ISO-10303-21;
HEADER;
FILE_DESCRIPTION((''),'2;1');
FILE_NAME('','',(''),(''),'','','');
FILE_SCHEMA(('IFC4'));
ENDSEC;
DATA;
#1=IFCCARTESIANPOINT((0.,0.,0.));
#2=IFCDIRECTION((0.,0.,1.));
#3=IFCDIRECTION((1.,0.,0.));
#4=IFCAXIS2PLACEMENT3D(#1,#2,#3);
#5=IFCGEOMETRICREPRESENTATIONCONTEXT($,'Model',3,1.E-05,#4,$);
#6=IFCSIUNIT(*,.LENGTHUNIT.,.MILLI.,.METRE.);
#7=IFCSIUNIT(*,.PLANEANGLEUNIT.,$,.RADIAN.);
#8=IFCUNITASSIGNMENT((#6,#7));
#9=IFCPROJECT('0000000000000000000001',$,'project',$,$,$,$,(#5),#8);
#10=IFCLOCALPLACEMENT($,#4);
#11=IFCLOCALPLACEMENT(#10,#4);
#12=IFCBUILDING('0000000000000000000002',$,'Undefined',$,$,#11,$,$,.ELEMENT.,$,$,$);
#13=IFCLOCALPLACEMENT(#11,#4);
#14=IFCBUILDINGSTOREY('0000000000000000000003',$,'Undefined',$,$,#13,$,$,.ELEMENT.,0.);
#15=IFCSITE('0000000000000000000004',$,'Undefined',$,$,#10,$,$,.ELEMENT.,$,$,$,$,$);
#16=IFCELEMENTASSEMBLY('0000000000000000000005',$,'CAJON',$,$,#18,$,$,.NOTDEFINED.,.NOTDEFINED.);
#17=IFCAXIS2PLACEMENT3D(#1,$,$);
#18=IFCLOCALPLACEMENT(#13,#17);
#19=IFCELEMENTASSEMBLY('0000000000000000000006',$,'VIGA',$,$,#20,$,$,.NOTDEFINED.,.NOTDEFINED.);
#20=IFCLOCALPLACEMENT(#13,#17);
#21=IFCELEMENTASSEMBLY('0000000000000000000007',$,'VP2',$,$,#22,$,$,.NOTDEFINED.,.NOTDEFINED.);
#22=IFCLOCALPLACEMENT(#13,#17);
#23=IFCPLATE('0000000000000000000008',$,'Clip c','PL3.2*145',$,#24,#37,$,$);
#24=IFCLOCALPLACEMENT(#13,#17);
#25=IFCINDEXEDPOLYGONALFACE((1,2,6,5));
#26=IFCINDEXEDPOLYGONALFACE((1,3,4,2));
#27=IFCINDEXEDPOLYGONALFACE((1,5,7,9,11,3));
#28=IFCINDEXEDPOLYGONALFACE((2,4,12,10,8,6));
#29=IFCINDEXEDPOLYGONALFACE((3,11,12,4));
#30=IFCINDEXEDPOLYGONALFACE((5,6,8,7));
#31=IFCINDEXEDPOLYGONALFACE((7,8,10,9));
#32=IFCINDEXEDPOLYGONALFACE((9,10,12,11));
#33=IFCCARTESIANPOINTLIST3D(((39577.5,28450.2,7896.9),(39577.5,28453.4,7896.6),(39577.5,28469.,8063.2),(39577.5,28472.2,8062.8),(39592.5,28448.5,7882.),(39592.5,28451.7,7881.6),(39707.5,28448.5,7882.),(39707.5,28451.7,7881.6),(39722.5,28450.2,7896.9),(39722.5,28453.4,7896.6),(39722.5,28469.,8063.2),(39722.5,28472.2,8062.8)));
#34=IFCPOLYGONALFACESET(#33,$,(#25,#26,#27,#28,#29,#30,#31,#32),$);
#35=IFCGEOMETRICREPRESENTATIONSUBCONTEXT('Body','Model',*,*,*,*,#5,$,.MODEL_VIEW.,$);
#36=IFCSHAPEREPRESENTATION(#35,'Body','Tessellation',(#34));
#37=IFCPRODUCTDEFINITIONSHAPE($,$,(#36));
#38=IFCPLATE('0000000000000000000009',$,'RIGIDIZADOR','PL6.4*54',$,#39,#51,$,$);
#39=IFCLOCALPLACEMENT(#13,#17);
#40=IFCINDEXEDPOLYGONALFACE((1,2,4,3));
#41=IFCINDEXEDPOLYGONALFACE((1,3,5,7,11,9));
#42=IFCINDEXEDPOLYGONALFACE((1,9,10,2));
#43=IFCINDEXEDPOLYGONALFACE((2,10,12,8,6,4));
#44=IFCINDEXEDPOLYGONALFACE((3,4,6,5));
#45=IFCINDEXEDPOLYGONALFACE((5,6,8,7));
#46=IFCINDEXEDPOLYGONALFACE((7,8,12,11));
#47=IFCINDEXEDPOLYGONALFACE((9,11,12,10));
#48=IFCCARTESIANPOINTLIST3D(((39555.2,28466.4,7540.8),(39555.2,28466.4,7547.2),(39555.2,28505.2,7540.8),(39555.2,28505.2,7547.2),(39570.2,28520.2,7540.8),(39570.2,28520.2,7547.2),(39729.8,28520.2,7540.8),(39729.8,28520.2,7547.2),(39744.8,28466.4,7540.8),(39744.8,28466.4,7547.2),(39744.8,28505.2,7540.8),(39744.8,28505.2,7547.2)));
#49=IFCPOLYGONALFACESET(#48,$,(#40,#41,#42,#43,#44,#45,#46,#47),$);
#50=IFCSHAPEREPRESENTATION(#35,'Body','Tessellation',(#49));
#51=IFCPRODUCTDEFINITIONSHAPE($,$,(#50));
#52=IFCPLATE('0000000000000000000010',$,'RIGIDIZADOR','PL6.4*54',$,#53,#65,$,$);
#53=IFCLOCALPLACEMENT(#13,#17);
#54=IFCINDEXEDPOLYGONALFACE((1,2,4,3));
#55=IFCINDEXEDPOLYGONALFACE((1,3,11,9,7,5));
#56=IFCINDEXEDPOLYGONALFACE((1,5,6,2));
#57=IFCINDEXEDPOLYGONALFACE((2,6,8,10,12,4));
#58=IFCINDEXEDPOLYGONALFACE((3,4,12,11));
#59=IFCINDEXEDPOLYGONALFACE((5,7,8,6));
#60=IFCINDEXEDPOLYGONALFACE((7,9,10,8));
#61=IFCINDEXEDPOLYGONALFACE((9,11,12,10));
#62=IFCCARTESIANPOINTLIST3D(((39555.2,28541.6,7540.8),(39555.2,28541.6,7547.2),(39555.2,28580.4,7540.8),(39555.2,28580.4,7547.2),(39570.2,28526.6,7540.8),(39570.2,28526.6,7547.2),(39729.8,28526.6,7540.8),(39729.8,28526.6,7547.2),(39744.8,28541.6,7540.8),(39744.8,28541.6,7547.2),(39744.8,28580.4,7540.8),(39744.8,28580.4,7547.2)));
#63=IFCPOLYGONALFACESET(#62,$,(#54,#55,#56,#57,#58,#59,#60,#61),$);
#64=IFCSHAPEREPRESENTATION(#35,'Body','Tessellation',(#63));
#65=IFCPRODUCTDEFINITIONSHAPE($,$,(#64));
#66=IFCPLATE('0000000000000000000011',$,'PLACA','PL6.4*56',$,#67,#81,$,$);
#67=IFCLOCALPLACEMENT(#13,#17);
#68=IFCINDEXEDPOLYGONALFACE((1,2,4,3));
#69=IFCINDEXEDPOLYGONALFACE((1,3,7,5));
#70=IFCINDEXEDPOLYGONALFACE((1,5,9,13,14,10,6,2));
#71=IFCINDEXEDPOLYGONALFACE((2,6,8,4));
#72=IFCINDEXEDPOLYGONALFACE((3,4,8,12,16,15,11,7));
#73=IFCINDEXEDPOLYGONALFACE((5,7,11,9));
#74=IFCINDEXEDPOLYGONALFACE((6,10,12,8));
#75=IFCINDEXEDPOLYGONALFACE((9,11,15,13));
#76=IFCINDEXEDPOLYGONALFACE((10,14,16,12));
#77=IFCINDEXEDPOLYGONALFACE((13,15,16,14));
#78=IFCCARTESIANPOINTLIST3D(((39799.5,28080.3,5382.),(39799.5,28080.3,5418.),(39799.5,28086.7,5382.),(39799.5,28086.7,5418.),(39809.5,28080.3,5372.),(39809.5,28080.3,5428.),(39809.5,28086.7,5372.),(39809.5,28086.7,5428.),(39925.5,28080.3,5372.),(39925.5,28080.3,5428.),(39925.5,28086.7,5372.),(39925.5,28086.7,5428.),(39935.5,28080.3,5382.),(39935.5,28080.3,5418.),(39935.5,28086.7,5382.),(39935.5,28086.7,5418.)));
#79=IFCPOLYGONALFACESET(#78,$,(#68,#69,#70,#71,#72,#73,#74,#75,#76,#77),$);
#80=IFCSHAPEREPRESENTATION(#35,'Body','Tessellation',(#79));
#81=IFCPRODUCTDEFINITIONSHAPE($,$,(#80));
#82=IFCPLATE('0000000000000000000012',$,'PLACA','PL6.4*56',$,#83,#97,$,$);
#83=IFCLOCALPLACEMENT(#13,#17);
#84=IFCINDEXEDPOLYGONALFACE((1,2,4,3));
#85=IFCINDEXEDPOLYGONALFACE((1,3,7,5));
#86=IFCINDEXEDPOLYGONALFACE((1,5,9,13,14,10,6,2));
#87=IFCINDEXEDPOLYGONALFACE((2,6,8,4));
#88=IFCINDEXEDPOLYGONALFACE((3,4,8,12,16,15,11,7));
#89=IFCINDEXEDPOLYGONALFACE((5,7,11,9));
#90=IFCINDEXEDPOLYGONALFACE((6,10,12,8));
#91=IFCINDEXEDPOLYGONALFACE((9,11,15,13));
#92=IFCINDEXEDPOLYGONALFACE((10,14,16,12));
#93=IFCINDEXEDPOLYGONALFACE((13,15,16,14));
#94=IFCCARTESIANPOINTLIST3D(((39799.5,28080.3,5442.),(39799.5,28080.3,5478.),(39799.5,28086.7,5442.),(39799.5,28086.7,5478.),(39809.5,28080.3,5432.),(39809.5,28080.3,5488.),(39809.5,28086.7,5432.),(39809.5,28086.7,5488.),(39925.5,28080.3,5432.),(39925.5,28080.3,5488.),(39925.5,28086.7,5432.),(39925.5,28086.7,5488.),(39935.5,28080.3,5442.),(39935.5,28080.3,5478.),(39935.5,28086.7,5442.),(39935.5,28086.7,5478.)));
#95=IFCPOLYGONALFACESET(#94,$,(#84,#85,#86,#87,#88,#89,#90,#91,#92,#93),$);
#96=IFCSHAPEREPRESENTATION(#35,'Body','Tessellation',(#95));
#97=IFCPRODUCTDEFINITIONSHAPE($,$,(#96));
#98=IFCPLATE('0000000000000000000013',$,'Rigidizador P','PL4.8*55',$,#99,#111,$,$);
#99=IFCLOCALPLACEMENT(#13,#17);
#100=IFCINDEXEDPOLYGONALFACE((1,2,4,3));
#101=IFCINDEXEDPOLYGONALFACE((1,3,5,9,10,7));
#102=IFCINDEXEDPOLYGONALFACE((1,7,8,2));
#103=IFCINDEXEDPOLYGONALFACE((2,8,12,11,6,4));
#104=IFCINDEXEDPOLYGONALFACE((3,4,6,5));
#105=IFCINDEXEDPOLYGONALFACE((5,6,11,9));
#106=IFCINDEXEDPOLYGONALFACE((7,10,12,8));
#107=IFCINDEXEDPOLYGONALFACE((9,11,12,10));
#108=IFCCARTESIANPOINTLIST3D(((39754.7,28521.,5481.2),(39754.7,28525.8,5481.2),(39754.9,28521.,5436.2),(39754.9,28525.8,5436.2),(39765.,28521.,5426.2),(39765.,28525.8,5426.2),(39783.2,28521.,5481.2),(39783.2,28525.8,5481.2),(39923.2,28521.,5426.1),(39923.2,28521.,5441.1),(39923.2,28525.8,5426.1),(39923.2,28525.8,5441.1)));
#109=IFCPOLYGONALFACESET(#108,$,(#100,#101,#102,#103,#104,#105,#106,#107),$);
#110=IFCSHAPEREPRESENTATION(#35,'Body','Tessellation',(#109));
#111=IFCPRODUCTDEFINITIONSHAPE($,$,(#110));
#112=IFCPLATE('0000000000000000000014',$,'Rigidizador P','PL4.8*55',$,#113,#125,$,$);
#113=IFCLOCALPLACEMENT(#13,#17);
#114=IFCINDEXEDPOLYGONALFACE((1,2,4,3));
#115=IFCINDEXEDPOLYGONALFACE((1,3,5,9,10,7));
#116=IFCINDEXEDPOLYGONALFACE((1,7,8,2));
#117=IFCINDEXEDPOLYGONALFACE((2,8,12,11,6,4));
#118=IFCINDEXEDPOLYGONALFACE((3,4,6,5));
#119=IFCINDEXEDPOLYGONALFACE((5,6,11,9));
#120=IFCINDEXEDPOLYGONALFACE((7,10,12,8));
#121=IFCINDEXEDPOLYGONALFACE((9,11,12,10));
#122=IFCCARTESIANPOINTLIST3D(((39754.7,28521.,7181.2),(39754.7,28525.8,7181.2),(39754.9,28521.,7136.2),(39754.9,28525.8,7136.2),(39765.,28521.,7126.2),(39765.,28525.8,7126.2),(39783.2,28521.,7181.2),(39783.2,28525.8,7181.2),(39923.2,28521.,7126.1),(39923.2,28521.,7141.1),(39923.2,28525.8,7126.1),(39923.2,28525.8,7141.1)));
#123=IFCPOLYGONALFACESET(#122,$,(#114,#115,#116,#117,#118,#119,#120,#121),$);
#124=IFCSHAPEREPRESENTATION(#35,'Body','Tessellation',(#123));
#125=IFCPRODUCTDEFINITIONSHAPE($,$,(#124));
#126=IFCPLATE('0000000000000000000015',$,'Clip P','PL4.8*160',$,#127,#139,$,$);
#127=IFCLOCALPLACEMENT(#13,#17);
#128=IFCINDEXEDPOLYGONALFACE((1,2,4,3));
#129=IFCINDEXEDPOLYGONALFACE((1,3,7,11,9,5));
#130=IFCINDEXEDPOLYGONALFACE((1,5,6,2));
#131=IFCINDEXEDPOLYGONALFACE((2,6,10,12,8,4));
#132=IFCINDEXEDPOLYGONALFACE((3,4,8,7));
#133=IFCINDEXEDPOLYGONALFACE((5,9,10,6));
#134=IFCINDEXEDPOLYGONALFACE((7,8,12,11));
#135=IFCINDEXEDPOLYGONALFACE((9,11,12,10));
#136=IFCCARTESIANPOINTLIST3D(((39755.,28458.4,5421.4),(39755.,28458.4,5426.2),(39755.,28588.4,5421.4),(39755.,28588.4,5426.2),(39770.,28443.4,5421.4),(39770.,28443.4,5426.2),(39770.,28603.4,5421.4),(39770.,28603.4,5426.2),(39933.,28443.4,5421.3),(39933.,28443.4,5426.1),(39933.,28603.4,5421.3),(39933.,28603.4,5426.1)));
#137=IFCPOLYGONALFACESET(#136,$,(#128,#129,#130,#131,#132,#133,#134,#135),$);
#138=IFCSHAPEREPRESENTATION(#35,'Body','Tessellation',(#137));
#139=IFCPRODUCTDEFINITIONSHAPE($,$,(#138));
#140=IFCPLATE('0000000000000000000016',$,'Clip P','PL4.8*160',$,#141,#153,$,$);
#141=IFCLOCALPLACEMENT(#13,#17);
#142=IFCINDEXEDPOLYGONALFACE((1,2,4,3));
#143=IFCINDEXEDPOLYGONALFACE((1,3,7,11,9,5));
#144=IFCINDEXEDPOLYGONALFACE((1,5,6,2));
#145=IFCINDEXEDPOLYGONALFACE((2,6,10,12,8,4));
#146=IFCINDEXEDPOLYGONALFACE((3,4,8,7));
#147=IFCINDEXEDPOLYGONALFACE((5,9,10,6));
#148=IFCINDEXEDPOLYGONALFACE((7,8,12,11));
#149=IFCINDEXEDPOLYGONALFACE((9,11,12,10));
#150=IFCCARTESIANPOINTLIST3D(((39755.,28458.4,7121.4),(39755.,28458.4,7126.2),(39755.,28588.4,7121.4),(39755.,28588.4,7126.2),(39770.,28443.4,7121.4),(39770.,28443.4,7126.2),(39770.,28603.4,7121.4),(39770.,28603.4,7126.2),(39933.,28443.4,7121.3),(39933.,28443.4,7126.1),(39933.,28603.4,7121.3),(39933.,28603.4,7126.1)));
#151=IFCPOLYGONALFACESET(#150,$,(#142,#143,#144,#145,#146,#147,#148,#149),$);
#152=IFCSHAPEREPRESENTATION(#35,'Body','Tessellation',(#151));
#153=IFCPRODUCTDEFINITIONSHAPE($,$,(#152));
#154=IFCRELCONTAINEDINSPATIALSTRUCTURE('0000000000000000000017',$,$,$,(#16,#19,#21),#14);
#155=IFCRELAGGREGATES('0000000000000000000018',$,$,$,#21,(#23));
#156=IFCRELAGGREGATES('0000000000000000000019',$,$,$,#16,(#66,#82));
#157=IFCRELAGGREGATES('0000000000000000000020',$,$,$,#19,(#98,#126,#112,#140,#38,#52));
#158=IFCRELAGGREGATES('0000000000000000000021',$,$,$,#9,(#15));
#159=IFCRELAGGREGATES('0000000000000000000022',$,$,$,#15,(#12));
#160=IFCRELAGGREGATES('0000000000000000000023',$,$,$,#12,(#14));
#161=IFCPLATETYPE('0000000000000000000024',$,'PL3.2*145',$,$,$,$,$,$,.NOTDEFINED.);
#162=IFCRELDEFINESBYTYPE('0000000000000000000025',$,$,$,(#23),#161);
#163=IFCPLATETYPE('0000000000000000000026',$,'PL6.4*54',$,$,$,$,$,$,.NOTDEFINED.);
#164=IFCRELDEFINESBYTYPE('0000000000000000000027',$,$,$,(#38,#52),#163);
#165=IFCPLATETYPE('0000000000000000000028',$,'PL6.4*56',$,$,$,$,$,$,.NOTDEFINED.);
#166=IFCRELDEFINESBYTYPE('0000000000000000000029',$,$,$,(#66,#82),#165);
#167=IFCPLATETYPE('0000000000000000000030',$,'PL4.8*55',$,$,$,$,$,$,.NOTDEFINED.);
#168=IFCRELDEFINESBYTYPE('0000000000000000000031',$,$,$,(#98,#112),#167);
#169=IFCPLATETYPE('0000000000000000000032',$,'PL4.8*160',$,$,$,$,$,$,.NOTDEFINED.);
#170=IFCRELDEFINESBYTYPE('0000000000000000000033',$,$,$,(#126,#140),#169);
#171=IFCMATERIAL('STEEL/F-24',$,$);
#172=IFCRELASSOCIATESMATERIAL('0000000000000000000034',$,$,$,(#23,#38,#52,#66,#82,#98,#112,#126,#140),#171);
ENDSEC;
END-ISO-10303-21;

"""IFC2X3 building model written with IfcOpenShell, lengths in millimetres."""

from ifc_helpers import new_model, si_unit, frame, origin_with_axes, place, context, subcontext, project, spatial, polyline, outline, extrude, material, type_object, element, aggregate, save


model = new_model("IFC2X3")

# Units and contexts
model_context = context("Model", 3, precision=1e-05, world=origin_with_axes())
body_context = subcontext(model_context, "Body", "Model", "MODEL_VIEW")
ifc_project = project(units=[si_unit("LENGTHUNIT", "METRE", prefix="MILLI"), si_unit("PLANEANGLEUNIT", "RADIAN")], contexts=[model_context])

# Site, building, storey
site_placement = place(None, origin_with_axes())
site = spatial("IfcSite", under=ifc_project, at=site_placement, Name="Undefined", CompositionType="ELEMENT")
building_placement = place(site_placement, origin_with_axes())
building = spatial("IfcBuilding", under=site, at=building_placement, Name="Undefined", CompositionType="ELEMENT")
storey_placement = place(building_placement, origin_with_axes())
storey = spatial("IfcBuildingStorey", under=building, at=storey_placement, Name="Undefined", CompositionType="ELEMENT", Elevation=0.0)

# Shared definitions
ifc_material_1 = material(Name="STEEL/F-24")

# Element assembly
assembly_1_placement = place(storey_placement, origin_with_axes())
assembly_1 = element("IfcElementAssembly", 1, at=assembly_1_placement, inside=storey, Name="CAJON", AssemblyPlace="NOTDEFINED", PredefinedType="NOTDEFINED")

# Element assemblies, plate
assembly_2_placement = place(storey_placement, origin_with_axes())
assembly_2 = element("IfcElementAssembly", 2, at=assembly_2_placement, inside=storey, Name="VIGA", AssemblyPlace="NOTDEFINED", PredefinedType="NOTDEFINED")
assembly_3_placement = place(storey_placement, origin_with_axes())
assembly_3 = element("IfcElementAssembly", 3, at=assembly_3_placement, inside=storey, Name="VP2", AssemblyPlace="NOTDEFINED", PredefinedType="NOTDEFINED")
plate_type_1 = type_object("IfcPlateType", Name="PL3.2*145", PredefinedType="NOTDEFINED")
plate_1_placement = place(assembly_3_placement, frame((39722.5, 28450.1, 7881.8), z_axis=(0.0, -0.993645, 0.112559), x_axis=(0.0, 0.112559, 0.993645)))
plate_1 = element("IfcPlate", 4, at=plate_1_placement, type_object=plate_type_1, material=ifc_material_1, Name="Clip c", Description="PL3.2*145", context=body_context, shape_type="SweptSolid", body=[
    extrude(outline(polyline([(0.0, 15.0), (15.0, 0.0), (182.3, 0.0), (182.3, 145.0), (15.0, 145.0), (0.0, 130.0), (0.0, 15.0)])), frame((0.0, 0.0, -1.6), z_axis=(0.0, 0.0, 1.0), x_axis=(1.0, 0.0, 0.0)), (0.0, 0.0, 1.0), 3.2),
])
aggregate(assembly_3, [plate_1])

# Plates
plate_type_2 = type_object("IfcPlateType", Name="PL6.4*54", PredefinedType="NOTDEFINED")
plate_2_placement = place(assembly_2_placement, frame((39744.8, 28466.4, 7544.0), z_axis=(0.0, 0.0, 1.0), x_axis=(0.0, 1.0, 0.0)))
plate_2 = element("IfcPlate", 5, at=plate_2_placement, type_object=plate_type_2, material=ifc_material_1, Name="RIGIDIZADOR", Description="PL6.4*54", context=body_context, shape_type="SweptSolid", body=[
    extrude(outline(polyline([(0.0, 0.0), (38.8, 0.0), (53.8, 15.0), (53.8, 174.6), (38.8, 189.6), (0.0, 189.6), (0.0, 0.0)])), frame((0.0, 0.0, -3.2), z_axis=(0.0, 0.0, 1.0), x_axis=(1.0, 0.0, 0.0)), (0.0, 0.0, 1.0), 6.4),
])
plate_3_placement = place(assembly_2_placement, frame((39744.8, 28526.6, 7544.0), z_axis=(0.0, 0.0, 1.0), x_axis=(0.0, 1.0, 0.0)))
plate_3 = element("IfcPlate", 6, at=plate_3_placement, type_object=plate_type_2, material=ifc_material_1, Name="RIGIDIZADOR", Description="PL6.4*54", context=body_context, shape_type="SweptSolid", body=[
    extrude(outline(polyline([(0.0, 15.0), (15.0, 0.0), (53.8, 0.0), (53.8, 189.6), (15.0, 189.6), (0.0, 174.6), (0.0, 15.0)])), frame((0.0, 0.0, -3.2), z_axis=(0.0, 0.0, 1.0), x_axis=(1.0, 0.0, 0.0)), (0.0, 0.0, 1.0), 6.4),
])
plate_type_3 = type_object("IfcPlateType", Name="PL6.4*56", PredefinedType="NOTDEFINED")
plate_4_placement = place(assembly_1_placement, frame((39799.5, 28083.5, 5428.0), z_axis=(0.0, -1.0, -0.000002), x_axis=(0.0, 0.000002, -1.0)))
plate_4 = element("IfcPlate", 7, at=plate_4_placement, type_object=plate_type_3, material=ifc_material_1, Name="PLACA", Description="PL6.4*56", context=body_context, shape_type="SweptSolid", body=[
    extrude(outline(polyline([(0.0, 10.0), (10.0, 0.0), (46.0, 0.0), (56.0, 10.0), (56.0, 126.0), (46.0, 136.0), (10.0, 136.0), (0.0, 126.0), (0.0, 10.0)])), frame((0.0, 0.0, -3.2), z_axis=(0.0, 0.0, 1.0), x_axis=(1.0, 0.0, 0.0)), (0.0, 0.0, 1.0), 6.4),
])
plate_5_placement = place(assembly_1_placement, frame((39799.5, 28083.5, 5432.0), z_axis=(0.0, 1.0, 0.000002), x_axis=(0.0, -0.000002, 1.0)))
plate_5 = element("IfcPlate", 8, at=plate_5_placement, type_object=plate_type_3, material=ifc_material_1, Name="PLACA", Description="PL6.4*56", context=body_context, shape_type="SweptSolid", body=[
    extrude(outline(polyline([(0.0, 10.0), (10.0, 0.0), (46.0, 0.0), (56.0, 10.0), (56.0, 126.0), (46.0, 136.0), (10.0, 136.0), (0.0, 126.0), (0.0, 10.0)])), frame((0.0, 0.0, -3.2), z_axis=(0.0, 0.0, 1.0), x_axis=(1.0, 0.0, 0.0)), (0.0, 0.0, 1.0), 6.4),
])
plate_type_4 = type_object("IfcPlateType", Name="PL4.8*55", PredefinedType="NOTDEFINED")
plate_6_placement = place(assembly_2_placement, frame((39923.2, 28523.4, 5426.1), z_axis=(0.0, -1.0, 0.0), x_axis=(0.000256, 0.0, 1.0)))
plate_6 = element("IfcPlate", 9, at=plate_6_placement, type_object=plate_type_4, material=ifc_material_1, Name="Rigidizador P", Description="PL4.8*55", context=body_context, shape_type="SweptSolid", body=[
    extrude(outline(polyline([(0.0, 0.0), (15.0, 0.0), (55.1, 140.0), (55.1, 168.5), (10.1, 168.2), (0.1, 158.2), (0.0, 0.0)])), frame((0.0, 0.0, -2.4), z_axis=(0.0, 0.0, 1.0), x_axis=(1.0, 0.0, 0.0)), (0.0, 0.0, 1.0), 4.8),
])
plate_7_placement = place(assembly_2_placement, frame((39923.2, 28523.4, 7126.1), z_axis=(0.0, -1.0, 0.0), x_axis=(0.000256, 0.0, 1.0)))
plate_7 = element("IfcPlate", 10, at=plate_7_placement, type_object=plate_type_4, material=ifc_material_1, Name="Rigidizador P", Description="PL4.8*55", context=body_context, shape_type="SweptSolid", body=[
    extrude(outline(polyline([(0.0, 0.0), (15.0, 0.0), (55.1, 140.0), (55.1, 168.5), (10.1, 168.2), (0.1, 158.2), (0.0, 0.0)])), frame((0.0, 0.0, -2.4), z_axis=(0.0, 0.0, 1.0), x_axis=(1.0, 0.0, 0.0)), (0.0, 0.0, 1.0), 4.8),
])
plate_type_5 = type_object("IfcPlateType", Name="PL4.8*160", PredefinedType="NOTDEFINED")
plate_8_placement = place(assembly_2_placement, frame((39755.0, 28443.4, 5423.8), z_axis=(0.000624, 0.0, 1.0), x_axis=(1.0, 0.0, -0.000624)))
plate_8 = element("IfcPlate", 11, at=plate_8_placement, type_object=plate_type_5, material=ifc_material_1, Name="Clip P", Description="PL4.8*160", context=body_context, shape_type="SweptSolid", body=[
    extrude(outline(polyline([(0.0, 15.0), (15.0, 0.0), (178.0, 0.0), (178.0, 160.0), (15.0, 160.0), (0.0, 145.0), (0.0, 15.0)])), frame((0.0, 0.0, -2.4), z_axis=(0.0, 0.0, 1.0), x_axis=(1.0, 0.0, 0.0)), (0.0, 0.0, 1.0), 4.8),
])
plate_9_placement = place(assembly_2_placement, frame((39755.0, 28443.4, 7123.8), z_axis=(0.000624, 0.0, 1.0), x_axis=(1.0, 0.0, -0.000624)))
plate_9 = element("IfcPlate", 12, at=plate_9_placement, type_object=plate_type_5, material=ifc_material_1, Name="Clip P", Description="PL4.8*160", context=body_context, shape_type="SweptSolid", body=[
    extrude(outline(polyline([(0.0, 15.0), (15.0, 0.0), (178.0, 0.0), (178.0, 160.0), (15.0, 160.0), (0.0, 145.0), (0.0, 15.0)])), frame((0.0, 0.0, -2.4), z_axis=(0.0, 0.0, 1.0), x_axis=(1.0, 0.0, 0.0)), (0.0, 0.0, 1.0), 4.8),
])

aggregate(assembly_1, [plate_4, plate_5])
aggregate(assembly_2, [plate_6, plate_8, plate_7, plate_9, plate_2, plate_3])

save(model, "model.ifc")
